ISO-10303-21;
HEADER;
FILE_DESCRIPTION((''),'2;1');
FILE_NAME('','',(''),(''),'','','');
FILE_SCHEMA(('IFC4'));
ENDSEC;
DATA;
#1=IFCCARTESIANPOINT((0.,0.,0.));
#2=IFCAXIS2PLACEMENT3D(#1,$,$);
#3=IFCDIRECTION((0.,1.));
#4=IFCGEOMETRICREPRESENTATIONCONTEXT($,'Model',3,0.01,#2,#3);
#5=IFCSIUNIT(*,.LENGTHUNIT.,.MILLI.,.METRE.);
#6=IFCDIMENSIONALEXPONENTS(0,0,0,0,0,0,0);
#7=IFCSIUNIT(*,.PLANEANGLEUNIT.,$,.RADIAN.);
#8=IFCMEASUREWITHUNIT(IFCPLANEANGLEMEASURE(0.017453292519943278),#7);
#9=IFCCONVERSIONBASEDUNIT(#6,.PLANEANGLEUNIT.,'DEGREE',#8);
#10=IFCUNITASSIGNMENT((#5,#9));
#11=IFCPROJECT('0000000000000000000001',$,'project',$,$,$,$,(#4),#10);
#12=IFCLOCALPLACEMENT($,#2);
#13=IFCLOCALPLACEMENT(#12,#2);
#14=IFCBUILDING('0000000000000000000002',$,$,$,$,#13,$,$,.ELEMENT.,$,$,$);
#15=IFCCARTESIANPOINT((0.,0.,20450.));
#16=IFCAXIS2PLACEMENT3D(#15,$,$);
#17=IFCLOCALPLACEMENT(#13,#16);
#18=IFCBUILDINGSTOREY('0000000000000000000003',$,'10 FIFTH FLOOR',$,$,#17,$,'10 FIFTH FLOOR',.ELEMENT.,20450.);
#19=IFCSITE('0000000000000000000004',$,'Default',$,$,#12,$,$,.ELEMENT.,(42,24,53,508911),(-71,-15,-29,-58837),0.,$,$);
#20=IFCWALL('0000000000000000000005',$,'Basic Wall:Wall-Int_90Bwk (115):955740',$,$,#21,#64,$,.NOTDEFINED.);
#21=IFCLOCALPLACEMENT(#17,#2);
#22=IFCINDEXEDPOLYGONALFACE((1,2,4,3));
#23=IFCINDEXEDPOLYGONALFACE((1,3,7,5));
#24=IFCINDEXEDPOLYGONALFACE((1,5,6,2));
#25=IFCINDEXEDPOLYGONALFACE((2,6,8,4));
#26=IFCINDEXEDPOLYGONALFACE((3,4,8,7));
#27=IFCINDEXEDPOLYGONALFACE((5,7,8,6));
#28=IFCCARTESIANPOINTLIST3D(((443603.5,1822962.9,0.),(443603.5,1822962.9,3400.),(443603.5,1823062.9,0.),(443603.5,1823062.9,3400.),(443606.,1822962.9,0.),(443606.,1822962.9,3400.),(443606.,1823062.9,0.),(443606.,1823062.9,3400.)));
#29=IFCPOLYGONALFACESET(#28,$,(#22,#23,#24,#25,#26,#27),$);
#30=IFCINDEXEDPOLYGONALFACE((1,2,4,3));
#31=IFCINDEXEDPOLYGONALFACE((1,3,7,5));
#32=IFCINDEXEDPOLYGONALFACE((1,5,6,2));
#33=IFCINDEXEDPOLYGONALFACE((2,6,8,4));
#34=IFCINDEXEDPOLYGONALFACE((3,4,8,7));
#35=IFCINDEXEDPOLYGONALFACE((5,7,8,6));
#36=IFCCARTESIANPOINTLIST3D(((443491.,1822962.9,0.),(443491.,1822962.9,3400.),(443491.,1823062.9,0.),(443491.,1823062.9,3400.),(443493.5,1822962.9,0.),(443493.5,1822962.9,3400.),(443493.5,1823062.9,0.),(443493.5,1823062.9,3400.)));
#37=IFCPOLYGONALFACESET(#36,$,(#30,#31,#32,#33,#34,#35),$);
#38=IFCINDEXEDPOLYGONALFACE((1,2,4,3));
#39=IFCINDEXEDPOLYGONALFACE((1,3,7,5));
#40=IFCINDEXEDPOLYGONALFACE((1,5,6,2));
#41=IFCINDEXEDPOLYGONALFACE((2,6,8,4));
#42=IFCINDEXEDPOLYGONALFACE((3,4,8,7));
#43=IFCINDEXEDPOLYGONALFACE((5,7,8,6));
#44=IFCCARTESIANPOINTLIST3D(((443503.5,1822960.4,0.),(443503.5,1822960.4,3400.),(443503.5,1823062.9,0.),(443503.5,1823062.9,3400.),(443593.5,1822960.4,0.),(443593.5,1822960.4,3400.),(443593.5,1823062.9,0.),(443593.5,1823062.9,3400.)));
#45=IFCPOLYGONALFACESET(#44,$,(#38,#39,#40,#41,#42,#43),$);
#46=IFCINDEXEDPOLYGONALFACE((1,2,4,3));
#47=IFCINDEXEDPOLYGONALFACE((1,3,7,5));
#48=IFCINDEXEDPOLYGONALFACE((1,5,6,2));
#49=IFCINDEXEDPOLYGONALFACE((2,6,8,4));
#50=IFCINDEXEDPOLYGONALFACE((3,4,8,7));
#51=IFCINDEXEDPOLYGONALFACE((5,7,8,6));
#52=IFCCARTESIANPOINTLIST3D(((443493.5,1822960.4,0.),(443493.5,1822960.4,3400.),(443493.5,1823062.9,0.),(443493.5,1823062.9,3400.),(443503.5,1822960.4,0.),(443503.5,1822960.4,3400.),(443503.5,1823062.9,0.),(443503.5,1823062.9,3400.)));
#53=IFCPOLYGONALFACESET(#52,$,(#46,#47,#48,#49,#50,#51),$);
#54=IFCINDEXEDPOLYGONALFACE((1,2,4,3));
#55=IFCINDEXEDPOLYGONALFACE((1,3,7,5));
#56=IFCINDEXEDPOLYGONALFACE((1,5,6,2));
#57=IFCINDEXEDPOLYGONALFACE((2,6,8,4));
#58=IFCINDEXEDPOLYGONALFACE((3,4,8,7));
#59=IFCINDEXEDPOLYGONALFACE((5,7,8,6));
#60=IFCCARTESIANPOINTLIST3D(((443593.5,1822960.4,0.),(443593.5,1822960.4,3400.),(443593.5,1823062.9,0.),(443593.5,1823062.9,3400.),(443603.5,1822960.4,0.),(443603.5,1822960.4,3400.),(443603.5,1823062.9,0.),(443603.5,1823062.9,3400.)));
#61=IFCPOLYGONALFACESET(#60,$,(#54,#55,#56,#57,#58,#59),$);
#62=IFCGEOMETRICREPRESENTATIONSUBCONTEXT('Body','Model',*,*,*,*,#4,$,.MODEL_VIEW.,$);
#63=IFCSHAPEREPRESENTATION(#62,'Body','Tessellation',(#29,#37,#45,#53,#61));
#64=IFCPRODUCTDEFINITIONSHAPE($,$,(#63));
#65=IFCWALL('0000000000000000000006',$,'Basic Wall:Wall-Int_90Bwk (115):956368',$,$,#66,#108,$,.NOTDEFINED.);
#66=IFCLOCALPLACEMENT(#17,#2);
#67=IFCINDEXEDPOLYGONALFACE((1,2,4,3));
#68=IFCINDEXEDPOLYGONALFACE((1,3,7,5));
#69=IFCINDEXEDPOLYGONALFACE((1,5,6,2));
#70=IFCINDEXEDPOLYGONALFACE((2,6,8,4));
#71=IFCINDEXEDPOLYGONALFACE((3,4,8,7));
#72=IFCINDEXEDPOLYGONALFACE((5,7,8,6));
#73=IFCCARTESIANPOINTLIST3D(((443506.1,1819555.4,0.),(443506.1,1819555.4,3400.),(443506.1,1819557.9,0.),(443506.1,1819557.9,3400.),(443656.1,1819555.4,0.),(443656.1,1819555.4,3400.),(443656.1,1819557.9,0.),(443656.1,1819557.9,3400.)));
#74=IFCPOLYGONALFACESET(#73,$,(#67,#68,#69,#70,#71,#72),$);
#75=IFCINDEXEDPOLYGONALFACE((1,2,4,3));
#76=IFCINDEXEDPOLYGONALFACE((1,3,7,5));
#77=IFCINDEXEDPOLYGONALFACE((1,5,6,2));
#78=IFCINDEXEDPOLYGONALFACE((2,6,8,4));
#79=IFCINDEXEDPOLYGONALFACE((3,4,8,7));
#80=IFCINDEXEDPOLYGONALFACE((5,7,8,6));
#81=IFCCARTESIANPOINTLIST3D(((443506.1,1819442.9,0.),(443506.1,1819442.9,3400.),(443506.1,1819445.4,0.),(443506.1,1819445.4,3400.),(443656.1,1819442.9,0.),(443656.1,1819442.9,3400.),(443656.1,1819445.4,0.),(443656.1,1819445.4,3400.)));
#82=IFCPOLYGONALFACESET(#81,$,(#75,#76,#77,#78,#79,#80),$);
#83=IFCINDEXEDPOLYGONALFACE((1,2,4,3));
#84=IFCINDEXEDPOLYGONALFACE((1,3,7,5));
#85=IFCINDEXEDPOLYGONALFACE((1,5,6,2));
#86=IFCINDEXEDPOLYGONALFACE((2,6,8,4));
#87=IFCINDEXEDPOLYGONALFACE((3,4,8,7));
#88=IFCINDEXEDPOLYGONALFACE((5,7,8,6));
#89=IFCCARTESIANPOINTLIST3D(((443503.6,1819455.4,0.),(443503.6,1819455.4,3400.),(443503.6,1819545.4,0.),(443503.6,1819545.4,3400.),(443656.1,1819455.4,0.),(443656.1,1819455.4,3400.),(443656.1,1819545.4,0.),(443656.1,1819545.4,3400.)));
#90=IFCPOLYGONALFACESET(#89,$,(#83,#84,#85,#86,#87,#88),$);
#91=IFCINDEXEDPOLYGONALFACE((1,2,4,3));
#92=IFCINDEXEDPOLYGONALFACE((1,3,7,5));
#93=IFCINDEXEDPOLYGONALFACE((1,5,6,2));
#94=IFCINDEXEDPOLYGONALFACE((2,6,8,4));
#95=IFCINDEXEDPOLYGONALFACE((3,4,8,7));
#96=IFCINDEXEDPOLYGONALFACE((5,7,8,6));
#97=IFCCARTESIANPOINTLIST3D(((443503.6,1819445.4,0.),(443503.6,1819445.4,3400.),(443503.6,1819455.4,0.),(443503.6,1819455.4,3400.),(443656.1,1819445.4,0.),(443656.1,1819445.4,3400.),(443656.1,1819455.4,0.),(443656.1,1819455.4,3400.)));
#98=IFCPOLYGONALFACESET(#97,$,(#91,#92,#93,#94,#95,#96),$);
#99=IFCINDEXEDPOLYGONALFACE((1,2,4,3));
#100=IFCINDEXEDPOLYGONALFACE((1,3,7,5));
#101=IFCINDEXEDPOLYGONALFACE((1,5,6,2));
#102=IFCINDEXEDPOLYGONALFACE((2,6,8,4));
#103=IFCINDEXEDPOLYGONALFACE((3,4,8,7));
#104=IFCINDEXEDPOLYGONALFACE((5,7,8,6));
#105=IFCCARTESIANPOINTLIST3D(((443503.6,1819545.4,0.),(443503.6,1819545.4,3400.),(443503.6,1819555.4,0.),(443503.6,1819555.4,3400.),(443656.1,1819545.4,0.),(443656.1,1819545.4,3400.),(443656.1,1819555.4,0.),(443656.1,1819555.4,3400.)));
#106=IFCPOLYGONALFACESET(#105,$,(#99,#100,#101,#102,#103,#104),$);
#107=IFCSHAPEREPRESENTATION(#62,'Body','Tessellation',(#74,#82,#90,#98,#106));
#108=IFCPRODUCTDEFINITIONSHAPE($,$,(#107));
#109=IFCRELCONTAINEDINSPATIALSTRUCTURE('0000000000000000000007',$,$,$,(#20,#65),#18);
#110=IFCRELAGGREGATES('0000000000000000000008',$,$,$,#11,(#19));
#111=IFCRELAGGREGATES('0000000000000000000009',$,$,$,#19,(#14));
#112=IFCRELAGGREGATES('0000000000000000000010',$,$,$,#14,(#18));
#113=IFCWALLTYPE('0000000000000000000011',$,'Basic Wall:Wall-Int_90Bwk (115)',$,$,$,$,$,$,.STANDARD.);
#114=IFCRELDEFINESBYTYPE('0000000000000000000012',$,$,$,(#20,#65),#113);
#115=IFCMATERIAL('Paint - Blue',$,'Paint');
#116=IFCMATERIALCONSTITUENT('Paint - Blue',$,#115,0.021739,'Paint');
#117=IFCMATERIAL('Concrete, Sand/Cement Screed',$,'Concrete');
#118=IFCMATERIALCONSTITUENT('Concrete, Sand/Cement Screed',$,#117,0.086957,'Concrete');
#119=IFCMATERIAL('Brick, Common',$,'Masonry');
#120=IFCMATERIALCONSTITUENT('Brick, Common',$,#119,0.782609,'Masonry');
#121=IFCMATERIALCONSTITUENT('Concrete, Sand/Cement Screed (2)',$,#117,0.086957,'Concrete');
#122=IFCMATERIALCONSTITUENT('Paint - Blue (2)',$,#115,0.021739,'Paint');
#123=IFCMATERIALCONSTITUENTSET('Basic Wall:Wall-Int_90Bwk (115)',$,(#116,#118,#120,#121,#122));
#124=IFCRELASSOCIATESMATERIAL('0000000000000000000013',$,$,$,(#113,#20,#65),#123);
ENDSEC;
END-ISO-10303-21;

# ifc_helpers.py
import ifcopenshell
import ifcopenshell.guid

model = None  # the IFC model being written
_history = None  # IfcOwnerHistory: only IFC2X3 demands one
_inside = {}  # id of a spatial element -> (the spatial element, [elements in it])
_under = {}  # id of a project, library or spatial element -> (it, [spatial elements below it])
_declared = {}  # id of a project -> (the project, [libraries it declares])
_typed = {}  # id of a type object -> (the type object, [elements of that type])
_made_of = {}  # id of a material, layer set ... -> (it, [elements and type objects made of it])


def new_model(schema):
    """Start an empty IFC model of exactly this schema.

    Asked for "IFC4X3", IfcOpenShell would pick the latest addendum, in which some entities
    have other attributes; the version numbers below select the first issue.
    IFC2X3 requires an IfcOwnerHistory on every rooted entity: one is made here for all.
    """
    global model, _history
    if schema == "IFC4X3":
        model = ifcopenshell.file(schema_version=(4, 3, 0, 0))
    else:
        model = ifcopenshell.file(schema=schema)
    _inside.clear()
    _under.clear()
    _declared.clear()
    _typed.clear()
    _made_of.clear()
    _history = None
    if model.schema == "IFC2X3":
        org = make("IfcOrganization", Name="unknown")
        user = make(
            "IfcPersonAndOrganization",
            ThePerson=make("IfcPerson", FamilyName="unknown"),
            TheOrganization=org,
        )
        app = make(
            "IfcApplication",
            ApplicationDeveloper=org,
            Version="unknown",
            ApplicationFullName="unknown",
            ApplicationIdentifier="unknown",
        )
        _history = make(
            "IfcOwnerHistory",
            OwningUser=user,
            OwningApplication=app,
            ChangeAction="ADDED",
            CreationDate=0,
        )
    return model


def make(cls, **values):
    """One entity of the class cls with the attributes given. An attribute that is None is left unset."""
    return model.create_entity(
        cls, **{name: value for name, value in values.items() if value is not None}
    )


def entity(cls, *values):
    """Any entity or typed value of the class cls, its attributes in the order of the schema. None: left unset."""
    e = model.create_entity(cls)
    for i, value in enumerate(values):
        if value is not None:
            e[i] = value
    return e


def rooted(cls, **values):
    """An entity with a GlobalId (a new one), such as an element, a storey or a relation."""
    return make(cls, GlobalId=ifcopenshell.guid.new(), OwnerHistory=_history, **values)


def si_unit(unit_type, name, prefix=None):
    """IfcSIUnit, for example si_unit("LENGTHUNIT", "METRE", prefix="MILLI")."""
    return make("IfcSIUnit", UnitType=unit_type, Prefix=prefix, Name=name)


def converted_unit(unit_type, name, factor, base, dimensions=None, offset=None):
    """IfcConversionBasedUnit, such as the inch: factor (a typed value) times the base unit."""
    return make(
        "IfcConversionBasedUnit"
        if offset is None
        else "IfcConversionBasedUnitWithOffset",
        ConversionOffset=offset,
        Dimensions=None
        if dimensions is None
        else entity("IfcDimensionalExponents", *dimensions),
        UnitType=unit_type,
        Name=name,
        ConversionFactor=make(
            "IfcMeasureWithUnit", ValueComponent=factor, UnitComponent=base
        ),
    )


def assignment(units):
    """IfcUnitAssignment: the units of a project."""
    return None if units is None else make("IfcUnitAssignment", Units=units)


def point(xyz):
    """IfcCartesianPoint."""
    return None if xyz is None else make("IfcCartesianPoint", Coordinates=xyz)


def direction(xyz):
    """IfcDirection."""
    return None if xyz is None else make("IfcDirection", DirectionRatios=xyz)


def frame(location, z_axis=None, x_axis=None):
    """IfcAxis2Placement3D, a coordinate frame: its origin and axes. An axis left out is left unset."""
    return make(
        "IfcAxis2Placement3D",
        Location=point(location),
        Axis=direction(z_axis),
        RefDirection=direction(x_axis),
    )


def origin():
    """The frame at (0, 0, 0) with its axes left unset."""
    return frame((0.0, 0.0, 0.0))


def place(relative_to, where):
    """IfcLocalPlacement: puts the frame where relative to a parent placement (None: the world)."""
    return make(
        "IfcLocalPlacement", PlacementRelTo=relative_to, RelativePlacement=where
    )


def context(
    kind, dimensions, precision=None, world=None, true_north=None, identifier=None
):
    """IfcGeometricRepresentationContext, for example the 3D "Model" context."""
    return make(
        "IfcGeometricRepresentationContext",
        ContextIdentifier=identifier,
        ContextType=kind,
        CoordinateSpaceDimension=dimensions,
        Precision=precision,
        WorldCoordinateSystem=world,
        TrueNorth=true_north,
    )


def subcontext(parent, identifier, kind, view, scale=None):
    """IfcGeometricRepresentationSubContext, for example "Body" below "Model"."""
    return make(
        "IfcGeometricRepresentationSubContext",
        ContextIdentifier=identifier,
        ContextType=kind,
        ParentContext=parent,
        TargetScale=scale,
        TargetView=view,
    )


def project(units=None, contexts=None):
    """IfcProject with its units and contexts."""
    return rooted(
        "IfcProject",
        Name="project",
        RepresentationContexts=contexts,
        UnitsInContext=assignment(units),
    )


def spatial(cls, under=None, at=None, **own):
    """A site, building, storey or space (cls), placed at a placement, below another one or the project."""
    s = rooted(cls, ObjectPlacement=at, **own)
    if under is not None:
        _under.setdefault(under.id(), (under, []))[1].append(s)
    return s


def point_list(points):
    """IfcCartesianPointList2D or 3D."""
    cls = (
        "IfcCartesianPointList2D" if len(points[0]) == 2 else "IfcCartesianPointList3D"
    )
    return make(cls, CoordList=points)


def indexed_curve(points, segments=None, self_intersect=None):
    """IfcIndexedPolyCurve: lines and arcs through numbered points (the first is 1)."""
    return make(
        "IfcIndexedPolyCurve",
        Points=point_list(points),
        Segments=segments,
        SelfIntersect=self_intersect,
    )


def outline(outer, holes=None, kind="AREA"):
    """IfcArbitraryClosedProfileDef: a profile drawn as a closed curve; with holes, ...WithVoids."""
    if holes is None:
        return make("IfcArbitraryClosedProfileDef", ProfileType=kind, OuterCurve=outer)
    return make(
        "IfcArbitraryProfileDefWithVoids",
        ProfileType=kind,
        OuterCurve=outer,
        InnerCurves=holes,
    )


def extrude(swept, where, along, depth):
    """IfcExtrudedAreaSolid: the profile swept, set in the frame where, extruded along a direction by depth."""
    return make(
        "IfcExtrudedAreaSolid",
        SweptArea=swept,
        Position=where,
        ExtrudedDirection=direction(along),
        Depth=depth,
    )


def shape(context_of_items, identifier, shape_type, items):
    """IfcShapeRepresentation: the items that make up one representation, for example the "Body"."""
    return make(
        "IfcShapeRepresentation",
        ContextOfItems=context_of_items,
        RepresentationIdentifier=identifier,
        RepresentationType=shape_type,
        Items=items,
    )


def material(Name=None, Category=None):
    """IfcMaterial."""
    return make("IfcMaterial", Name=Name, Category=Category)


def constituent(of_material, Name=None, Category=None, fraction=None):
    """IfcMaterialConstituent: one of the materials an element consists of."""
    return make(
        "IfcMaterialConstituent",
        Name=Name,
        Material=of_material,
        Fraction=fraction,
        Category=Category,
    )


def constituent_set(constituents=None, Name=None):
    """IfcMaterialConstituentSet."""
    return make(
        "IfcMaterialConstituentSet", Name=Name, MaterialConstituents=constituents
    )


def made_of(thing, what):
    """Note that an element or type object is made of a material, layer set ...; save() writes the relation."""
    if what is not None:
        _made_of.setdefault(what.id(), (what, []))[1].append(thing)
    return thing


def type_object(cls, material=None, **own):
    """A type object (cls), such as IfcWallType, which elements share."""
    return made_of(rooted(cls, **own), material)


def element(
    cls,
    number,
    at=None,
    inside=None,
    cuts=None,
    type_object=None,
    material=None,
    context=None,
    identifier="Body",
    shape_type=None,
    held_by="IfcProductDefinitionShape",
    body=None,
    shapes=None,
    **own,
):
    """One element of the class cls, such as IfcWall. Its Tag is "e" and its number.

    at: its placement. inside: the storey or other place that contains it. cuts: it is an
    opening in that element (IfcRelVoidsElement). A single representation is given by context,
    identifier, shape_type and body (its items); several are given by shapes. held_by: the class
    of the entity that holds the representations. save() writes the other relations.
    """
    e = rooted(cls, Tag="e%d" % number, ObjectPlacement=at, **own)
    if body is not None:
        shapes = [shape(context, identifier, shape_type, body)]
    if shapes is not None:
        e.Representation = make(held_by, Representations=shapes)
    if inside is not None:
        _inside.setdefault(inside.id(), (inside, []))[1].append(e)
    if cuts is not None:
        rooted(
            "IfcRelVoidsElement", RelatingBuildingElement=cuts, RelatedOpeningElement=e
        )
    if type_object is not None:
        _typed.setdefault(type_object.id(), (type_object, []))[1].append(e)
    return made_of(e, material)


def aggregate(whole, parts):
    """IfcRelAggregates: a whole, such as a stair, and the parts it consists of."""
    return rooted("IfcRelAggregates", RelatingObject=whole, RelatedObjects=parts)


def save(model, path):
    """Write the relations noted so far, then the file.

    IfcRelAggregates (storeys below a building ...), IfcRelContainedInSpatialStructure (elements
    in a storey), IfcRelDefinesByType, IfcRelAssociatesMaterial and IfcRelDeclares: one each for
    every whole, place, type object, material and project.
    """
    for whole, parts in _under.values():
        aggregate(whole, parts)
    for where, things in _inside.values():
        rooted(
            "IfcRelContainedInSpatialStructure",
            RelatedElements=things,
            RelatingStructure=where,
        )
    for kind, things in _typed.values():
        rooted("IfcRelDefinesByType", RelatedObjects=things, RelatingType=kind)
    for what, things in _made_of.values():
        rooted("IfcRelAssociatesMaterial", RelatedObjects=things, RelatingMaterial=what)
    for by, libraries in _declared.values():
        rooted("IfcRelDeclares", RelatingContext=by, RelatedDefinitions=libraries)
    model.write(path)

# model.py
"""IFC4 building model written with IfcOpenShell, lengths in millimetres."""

from ifc_helpers import new_model, entity, si_unit, converted_unit, direction, frame, origin, place, context, subcontext, project, spatial, indexed_curve, outline, extrude, material, constituent, constituent_set, type_object, element, save


model = new_model("IFC4")

# Units and contexts
model_context = context("Model", 3, precision=0.01, world=origin(), true_north=direction((0.0, 1.0)))
body_context = subcontext(model_context, "Body", "Model", "MODEL_VIEW")
ifc_project = project(units=[si_unit("LENGTHUNIT", "METRE", prefix="MILLI"), converted_unit("PLANEANGLEUNIT", "DEGREE", entity("IfcPlaneAngleMeasure", 0.017453292519943278), si_unit("PLANEANGLEUNIT", "RADIAN"), dimensions=[0, 0, 0, 0, 0, 0, 0])], contexts=[model_context])

# Site, building, storey
site_placement = place(None, origin())
site = spatial("IfcSite", under=ifc_project, at=site_placement, Name="Default", CompositionType="ELEMENT", RefLatitude=(42, 24, 53, 508911), RefLongitude=(-71, -15, -29, -58837), RefElevation=0.0)
building_placement = place(site_placement, origin())
building = spatial("IfcBuilding", under=site, at=building_placement, CompositionType="ELEMENT")
storey_placement = place(building_placement, frame((0.0, 0.0, 20450.0)))
storey = spatial("IfcBuildingStorey", under=building, at=storey_placement, Name="10 FIFTH FLOOR", LongName="10 FIFTH FLOOR", CompositionType="ELEMENT", Elevation=20450.0)

# Shared definitions
ifc_material_1 = material(Name="Paint - Blue", Category="Paint")
ifc_constituent_1 = constituent(ifc_material_1, Name="Paint - Blue", Category="Paint", fraction=0.021739)
ifc_material_2 = material(Name="Concrete, Sand/Cement Screed", Category="Concrete")
ifc_constituent_2 = constituent(ifc_material_2, Name="Concrete, Sand/Cement Screed", Category="Concrete", fraction=0.086957)
ifc_material_3 = material(Name="Brick, Common", Category="Masonry")
ifc_constituent_3 = constituent(ifc_material_3, Name="Brick, Common", Category="Masonry", fraction=0.782609)
ifc_constituent_4 = constituent(ifc_material_2, Name="Concrete, Sand/Cement Screed (2)", Category="Concrete", fraction=0.086957)
ifc_constituent_5 = constituent(ifc_material_1, Name="Paint - Blue (2)", Category="Paint", fraction=0.021739)
ifc_constituent_set_1 = constituent_set(constituents=[ifc_constituent_1, ifc_constituent_2, ifc_constituent_3, ifc_constituent_4, ifc_constituent_5], Name="Basic Wall:Wall-Int_90Bwk (115)")
wall_type_1 = type_object("IfcWallType", Name="Basic Wall:Wall-Int_90Bwk (115)", PredefinedType="STANDARD", material=ifc_constituent_set_1)

# Wall
wall_1_placement = place(storey_placement, frame((443548.5, 1823062.9, 0.0), z_axis=(0.0, 0.0, 1.0), x_axis=(0.0, -1.0, 0.0)))
element("IfcWall", 1, at=wall_1_placement, inside=storey, type_object=wall_type_1, material=ifc_constituent_set_1, Name="Basic Wall:Wall-Int_90Bwk (115):955740", PredefinedType="NOTDEFINED", context=body_context, shape_type="SweptSolid", body=[
    extrude(outline(indexed_curve([(-1.3, -50.0), (1.2, -50.0), (1.2, 50.0), (-1.3, 50.0), (-1.3, -50.0)], self_intersect=False)), frame((50.0, 56.2, 0.0), z_axis=(0.0, 0.0, 1.0), x_axis=(0.0, -1.0, 0.0)), (0.0, 0.0, 1.0), 3400.0),
    extrude(outline(indexed_curve([(-1.3, -50.0), (1.2, -50.0), (1.2, 50.0), (-1.3, 50.0), (-1.3, -50.0)], self_intersect=False)), frame((50.0, -56.2, 0.0), z_axis=(0.0, 0.0, 1.0), x_axis=(0.0, 1.0, 0.0)), (0.0, 0.0, 1.0), 3400.0),
    extrude(outline(indexed_curve([(-51.3, -45.0), (51.3, -45.0), (51.3, 45.0), (-51.3, 45.0), (-51.3, -45.0)], self_intersect=False)), frame((51.3, 0.0, 0.0)), (0.0, 0.0, 1.0), 3400.0),
    extrude(outline(indexed_curve([(-51.3, -5.0), (51.3, -5.0), (51.3, 5.0), (-51.3, 5.0), (-51.3, -5.0)], self_intersect=False)), frame((51.3, -50.0, 0.0)), (0.0, 0.0, 1.0), 3400.0),
    extrude(outline(indexed_curve([(-51.3, -5.0), (51.3, -5.0), (51.3, 5.0), (-51.3, 5.0), (-51.3, -5.0)], self_intersect=False)), frame((51.3, 50.0, 0.0)), (0.0, 0.0, 1.0), 3400.0),
])

# Wall
wall_2_placement = place(storey_placement, frame((443656.1, 1819500.4, 0.0), z_axis=(0.0, 0.0, 1.0), x_axis=(-1.0, 0.0, 0.0)))
element("IfcWall", 2, at=wall_2_placement, inside=storey, type_object=wall_type_1, material=ifc_constituent_set_1, Name="Basic Wall:Wall-Int_90Bwk (115):956368", PredefinedType="NOTDEFINED", context=body_context, shape_type="SweptSolid", body=[
    extrude(outline(indexed_curve([(-1.3, -75.0), (1.2, -75.0), (1.2, 75.0), (-1.3, 75.0), (-1.3, -75.0)], self_intersect=False)), frame((75.0, -56.2, 0.0), z_axis=(0.0, 0.0, 1.0), x_axis=(0.0, 1.0, 0.0)), (0.0, 0.0, 1.0), 3400.0),
    extrude(outline(indexed_curve([(-1.3, -75.0), (1.3, -75.0), (1.3, 75.0), (-1.3, 75.0), (-1.3, -75.0)], self_intersect=False)), frame((75.0, 56.3, 0.0), z_axis=(0.0, 0.0, 1.0), x_axis=(0.0, -1.0, 0.0)), (0.0, 0.0, 1.0), 3400.0),
    extrude(outline(indexed_curve([(-76.2, -45.0), (76.2, -45.0), (76.2, 45.0), (-76.2, 45.0), (-76.2, -45.0)], self_intersect=False)), frame((76.2, 0.0, 0.0)), (0.0, 0.0, 1.0), 3400.0),
    extrude(outline(indexed_curve([(-76.2, -5.0), (76.2, -5.0), (76.2, 5.0), (-76.2, 5.0), (-76.2, -5.0)], self_intersect=False)), frame((76.2, 50.0, 0.0)), (0.0, 0.0, 1.0), 3400.0),
    extrude(outline(indexed_curve([(-76.2, -5.0), (76.2, -5.0), (76.2, 5.0), (-76.2, 5.0), (-76.2, -5.0)], self_intersect=False)), frame((76.2, -50.0, 0.0)), (0.0, 0.0, 1.0), 3400.0),
])

save(model, "model.ifc")
